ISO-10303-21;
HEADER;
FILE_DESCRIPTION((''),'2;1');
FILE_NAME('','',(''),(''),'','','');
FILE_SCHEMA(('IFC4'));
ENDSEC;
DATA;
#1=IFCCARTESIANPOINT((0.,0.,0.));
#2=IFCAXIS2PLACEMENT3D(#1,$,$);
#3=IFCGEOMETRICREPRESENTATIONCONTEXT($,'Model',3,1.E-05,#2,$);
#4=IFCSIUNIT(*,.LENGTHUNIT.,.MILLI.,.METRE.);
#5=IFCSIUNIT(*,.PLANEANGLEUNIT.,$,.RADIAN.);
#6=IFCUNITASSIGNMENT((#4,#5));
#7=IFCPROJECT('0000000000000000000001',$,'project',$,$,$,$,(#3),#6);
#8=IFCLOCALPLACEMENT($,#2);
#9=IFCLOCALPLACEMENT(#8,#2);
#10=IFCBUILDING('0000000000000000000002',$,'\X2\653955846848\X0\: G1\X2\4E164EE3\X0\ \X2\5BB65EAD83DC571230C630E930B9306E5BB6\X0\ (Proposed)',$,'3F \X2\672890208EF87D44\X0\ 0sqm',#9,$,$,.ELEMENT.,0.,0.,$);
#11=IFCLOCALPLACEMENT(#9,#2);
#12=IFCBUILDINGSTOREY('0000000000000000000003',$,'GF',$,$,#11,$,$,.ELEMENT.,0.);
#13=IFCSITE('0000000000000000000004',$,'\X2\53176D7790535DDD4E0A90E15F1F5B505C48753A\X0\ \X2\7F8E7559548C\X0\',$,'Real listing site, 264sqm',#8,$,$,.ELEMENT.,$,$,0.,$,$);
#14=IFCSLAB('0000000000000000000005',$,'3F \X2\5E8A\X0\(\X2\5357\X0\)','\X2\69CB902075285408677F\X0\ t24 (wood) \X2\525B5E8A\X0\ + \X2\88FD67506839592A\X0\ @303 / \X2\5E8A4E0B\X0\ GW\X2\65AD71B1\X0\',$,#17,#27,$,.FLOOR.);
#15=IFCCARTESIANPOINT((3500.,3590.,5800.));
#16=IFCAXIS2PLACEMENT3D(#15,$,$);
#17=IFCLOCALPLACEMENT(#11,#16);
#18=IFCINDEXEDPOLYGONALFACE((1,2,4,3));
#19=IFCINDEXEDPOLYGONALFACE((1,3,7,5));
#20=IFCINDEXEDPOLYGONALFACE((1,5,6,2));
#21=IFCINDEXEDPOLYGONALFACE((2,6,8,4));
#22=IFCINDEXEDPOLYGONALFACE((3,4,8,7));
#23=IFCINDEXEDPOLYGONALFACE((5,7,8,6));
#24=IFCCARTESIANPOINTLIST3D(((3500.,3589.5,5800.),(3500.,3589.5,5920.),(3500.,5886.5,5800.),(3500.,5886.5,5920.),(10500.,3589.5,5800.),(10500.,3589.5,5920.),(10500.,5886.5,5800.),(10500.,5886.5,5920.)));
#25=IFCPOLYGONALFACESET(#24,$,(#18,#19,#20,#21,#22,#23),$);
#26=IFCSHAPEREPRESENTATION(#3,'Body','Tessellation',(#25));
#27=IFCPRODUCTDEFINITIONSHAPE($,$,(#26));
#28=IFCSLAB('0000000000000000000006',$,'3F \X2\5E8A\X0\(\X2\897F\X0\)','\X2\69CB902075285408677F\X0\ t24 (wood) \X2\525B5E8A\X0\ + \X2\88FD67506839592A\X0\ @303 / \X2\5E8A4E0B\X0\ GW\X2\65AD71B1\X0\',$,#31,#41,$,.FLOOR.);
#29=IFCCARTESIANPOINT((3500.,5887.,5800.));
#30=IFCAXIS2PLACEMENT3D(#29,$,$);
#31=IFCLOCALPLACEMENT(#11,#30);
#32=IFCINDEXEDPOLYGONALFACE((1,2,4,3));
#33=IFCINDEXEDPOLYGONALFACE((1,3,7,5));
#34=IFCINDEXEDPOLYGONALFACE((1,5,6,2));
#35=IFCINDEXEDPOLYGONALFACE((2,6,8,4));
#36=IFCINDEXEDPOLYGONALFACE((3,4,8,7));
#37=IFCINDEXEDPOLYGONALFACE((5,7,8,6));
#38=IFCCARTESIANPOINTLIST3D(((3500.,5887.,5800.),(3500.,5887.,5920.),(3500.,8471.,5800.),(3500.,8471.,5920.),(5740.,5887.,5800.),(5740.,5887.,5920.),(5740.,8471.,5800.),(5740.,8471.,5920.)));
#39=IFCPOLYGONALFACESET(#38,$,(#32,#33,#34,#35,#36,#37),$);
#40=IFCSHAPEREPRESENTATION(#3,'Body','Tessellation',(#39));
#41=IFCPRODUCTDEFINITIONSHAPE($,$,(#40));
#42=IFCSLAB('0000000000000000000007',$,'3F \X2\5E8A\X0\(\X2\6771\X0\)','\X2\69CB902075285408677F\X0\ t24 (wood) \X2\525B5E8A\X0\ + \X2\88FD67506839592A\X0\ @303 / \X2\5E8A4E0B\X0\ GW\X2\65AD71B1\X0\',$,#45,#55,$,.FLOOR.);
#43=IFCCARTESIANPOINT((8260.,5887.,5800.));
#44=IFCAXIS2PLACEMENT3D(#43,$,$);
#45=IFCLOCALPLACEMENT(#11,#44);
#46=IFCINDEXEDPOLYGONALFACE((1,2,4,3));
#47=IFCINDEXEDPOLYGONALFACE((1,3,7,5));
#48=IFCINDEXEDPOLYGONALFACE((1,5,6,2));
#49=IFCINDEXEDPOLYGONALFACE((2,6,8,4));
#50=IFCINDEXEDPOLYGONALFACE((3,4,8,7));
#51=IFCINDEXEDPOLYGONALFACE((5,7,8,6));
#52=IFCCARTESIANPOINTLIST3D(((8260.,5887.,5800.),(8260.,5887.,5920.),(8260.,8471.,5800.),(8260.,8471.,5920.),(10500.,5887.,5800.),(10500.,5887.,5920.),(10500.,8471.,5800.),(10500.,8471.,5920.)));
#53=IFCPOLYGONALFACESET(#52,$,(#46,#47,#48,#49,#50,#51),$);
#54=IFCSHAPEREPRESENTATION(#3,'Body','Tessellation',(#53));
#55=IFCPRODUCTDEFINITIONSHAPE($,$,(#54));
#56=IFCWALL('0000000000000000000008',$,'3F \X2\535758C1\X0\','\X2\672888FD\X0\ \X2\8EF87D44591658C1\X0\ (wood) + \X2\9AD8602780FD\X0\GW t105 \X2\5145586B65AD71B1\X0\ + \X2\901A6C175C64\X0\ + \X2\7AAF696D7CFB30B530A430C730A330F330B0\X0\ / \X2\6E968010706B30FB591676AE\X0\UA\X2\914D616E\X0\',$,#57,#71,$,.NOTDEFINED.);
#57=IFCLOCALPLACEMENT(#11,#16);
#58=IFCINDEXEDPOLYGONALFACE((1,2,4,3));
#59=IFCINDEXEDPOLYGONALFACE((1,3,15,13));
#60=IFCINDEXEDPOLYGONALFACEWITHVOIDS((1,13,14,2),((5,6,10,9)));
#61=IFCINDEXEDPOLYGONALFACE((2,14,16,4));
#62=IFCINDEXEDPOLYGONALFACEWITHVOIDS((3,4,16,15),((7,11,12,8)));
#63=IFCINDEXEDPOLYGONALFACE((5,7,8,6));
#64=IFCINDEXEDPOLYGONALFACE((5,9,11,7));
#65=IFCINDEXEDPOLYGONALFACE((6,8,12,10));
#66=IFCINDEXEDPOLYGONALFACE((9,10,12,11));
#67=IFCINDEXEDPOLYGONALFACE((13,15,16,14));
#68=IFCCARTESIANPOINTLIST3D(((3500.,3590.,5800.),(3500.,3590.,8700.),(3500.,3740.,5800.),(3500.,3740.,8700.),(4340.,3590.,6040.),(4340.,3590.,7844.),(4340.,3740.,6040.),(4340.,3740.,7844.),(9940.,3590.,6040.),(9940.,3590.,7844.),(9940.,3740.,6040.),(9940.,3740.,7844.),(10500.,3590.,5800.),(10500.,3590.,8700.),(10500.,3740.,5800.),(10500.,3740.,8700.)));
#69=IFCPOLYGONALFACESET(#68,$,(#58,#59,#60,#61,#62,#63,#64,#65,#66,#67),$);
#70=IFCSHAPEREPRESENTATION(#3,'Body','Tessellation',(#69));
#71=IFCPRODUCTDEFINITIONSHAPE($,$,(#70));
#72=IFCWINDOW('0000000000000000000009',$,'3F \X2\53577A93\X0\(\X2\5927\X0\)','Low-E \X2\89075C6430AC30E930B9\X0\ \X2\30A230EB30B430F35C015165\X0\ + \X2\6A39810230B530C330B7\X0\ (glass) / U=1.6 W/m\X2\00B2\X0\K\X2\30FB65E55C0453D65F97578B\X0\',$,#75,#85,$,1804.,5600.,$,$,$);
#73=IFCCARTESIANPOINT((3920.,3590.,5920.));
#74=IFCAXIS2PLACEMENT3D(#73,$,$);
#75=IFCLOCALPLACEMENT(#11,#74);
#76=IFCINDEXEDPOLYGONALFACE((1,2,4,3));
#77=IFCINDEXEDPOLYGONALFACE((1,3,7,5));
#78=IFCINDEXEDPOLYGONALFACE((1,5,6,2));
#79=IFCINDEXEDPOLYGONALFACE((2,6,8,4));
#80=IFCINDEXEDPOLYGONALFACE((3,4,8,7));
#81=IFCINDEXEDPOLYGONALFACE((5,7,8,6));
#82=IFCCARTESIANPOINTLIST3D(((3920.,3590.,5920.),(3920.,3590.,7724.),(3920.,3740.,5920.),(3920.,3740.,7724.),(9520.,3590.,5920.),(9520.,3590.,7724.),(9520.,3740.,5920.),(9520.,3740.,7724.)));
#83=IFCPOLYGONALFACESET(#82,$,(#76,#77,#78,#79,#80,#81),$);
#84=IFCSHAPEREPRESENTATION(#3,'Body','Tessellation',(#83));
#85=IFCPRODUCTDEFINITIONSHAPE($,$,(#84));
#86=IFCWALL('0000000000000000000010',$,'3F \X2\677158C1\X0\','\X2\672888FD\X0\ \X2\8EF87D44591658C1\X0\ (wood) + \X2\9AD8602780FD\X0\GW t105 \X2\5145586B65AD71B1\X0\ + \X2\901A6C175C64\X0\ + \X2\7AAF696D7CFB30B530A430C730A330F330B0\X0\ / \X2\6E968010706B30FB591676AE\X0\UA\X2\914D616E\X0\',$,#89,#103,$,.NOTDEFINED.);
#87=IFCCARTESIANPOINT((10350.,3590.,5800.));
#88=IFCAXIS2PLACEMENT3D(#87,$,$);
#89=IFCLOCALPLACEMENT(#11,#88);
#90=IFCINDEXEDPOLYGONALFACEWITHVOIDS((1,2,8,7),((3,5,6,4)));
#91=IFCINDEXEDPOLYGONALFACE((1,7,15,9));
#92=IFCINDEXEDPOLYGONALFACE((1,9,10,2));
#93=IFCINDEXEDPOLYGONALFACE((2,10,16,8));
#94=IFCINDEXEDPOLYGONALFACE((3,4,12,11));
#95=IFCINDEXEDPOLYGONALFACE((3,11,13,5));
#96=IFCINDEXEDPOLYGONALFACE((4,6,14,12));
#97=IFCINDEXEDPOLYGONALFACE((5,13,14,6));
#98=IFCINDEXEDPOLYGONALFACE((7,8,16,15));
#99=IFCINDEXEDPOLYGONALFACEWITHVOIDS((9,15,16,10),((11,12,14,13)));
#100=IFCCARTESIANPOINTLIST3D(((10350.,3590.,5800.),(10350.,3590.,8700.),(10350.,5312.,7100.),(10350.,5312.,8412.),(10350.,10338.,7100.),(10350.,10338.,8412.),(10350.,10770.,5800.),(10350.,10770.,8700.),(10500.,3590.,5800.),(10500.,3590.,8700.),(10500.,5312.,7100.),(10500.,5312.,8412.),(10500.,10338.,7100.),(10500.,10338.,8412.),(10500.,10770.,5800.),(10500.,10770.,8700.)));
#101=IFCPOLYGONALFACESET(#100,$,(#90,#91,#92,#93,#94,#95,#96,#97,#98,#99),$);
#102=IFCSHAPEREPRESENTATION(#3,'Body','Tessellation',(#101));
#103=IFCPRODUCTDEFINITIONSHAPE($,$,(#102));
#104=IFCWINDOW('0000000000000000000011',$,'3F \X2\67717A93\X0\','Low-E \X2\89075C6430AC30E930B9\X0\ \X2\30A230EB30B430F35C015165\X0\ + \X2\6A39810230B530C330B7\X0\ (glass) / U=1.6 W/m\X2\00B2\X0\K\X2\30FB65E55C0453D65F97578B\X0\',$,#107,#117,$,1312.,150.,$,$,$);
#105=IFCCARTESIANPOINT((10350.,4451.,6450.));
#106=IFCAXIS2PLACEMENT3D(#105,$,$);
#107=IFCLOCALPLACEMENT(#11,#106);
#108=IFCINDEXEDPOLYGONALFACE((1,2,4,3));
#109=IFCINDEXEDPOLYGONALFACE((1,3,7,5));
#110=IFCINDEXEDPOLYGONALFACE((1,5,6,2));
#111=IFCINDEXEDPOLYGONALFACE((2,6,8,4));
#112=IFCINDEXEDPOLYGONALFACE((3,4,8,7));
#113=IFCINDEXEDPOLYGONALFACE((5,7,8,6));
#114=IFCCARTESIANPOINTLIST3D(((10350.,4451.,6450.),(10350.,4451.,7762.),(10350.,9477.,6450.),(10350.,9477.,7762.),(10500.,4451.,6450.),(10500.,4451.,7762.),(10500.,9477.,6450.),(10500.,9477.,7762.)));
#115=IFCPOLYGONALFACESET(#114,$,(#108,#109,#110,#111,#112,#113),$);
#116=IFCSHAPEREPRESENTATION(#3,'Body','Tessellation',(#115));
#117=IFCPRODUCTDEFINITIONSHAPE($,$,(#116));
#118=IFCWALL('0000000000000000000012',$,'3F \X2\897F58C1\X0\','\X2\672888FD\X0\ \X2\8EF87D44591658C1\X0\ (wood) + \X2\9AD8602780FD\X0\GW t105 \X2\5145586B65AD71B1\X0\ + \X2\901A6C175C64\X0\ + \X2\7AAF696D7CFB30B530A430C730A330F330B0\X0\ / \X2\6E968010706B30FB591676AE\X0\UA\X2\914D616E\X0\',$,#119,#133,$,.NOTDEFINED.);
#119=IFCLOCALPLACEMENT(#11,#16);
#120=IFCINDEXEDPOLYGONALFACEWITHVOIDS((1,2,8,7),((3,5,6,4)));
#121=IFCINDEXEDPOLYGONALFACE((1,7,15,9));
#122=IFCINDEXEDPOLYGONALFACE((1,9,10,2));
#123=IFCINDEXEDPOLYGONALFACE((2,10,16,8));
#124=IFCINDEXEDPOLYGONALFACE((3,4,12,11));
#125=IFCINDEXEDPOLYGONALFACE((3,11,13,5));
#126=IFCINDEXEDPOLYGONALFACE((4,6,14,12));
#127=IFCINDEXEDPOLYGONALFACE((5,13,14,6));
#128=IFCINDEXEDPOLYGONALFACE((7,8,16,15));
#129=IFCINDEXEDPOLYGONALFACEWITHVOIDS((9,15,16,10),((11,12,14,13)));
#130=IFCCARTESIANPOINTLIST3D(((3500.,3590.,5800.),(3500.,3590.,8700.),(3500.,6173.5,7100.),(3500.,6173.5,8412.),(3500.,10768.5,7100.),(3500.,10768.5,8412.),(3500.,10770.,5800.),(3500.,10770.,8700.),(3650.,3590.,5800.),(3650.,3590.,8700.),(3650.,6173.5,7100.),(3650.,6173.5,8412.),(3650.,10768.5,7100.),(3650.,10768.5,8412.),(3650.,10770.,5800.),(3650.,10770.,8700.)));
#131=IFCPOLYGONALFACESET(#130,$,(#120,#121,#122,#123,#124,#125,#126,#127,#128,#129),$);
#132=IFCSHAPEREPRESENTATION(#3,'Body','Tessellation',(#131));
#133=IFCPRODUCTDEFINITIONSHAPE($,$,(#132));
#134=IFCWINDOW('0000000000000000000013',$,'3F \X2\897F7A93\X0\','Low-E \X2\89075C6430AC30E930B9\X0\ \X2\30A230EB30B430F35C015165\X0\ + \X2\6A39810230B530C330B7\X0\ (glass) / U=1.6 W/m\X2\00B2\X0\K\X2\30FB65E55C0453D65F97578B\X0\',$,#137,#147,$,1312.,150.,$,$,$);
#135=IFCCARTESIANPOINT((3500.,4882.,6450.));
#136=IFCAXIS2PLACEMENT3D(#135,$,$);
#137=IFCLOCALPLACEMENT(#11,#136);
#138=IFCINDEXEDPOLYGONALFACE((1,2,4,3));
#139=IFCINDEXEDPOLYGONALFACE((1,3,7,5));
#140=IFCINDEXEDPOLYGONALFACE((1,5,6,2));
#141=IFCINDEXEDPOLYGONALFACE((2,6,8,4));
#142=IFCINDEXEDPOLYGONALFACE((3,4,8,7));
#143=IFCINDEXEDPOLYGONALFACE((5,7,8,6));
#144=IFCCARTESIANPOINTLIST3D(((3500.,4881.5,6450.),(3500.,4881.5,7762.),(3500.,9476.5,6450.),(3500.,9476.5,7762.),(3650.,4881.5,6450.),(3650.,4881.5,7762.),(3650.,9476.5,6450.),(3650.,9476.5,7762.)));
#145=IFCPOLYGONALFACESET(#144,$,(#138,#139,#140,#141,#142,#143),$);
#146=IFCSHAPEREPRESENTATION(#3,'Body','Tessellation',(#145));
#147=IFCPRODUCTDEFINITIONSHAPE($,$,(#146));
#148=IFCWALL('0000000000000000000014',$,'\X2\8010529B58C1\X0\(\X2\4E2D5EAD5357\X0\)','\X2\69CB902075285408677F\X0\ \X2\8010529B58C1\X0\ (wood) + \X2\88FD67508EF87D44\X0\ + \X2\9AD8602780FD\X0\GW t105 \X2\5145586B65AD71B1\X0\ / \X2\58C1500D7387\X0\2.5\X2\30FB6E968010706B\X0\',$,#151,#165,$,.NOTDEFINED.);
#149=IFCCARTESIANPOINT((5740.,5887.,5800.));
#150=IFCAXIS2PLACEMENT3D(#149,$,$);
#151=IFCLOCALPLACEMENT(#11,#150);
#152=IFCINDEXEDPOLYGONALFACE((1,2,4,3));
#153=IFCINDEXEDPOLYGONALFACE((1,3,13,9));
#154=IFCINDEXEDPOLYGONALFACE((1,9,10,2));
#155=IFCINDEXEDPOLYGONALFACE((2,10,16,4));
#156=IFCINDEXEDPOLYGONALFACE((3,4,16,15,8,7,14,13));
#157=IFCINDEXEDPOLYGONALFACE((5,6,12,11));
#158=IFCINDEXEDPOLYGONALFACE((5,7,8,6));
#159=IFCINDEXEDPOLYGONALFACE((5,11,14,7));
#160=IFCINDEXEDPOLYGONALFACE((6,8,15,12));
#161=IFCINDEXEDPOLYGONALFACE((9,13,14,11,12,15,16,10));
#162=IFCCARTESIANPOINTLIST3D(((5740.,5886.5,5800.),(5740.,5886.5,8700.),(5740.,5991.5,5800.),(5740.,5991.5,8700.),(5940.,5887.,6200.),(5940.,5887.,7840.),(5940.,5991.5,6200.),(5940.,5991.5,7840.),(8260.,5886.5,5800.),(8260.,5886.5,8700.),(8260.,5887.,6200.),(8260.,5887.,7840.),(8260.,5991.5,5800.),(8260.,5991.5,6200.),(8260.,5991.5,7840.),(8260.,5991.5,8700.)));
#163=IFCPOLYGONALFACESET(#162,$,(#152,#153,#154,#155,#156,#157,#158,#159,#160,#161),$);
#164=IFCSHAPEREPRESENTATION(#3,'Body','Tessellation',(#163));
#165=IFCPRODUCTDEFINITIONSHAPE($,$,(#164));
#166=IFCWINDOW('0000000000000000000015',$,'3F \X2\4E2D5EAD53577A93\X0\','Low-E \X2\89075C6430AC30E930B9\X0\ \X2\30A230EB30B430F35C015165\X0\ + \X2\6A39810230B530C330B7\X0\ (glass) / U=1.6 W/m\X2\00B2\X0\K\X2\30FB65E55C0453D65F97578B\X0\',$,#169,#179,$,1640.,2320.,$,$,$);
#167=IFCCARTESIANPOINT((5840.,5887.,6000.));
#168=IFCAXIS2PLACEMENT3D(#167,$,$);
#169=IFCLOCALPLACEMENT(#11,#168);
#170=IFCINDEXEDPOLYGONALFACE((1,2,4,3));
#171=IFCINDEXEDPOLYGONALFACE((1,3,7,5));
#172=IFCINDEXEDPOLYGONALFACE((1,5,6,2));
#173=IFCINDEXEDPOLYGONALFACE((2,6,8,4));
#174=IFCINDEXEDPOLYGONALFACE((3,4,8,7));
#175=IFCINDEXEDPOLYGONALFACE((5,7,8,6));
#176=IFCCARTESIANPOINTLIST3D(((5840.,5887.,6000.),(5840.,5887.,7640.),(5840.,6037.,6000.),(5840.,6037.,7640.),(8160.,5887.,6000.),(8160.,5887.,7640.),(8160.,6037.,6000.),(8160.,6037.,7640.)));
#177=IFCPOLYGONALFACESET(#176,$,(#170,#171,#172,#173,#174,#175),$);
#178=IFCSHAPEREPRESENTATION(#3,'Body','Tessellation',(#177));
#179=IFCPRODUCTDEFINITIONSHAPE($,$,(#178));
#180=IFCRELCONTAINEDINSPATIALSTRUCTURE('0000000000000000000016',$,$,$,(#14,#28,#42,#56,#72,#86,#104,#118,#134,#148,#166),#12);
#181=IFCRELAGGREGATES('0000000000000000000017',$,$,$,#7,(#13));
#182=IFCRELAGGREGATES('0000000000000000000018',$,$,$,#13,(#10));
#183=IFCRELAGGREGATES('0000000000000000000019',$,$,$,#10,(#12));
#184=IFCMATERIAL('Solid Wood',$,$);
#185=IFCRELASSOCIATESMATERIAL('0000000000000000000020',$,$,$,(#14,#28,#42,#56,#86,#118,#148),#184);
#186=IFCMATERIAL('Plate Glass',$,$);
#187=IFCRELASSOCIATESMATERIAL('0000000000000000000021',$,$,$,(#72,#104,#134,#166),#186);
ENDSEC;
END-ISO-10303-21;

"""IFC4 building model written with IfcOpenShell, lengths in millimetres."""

from ifc_helpers import new_model, si_unit, frame, frame_2d, origin, place, context, project, spatial, rectangle, extrude, material, element, fill, save


model = new_model("IFC4")

# Units and contexts
model_context = context("Model", 3, precision=1e-05, world=origin())
ifc_project = project(units=[si_unit("LENGTHUNIT", "METRE", prefix="MILLI"), si_unit("PLANEANGLEUNIT", "RADIAN")], contexts=[model_context])

# Site, building, storey
site_placement = place(None, origin())
site = spatial("IfcSite", under=ifc_project, at=site_placement, Name="北海道川上郡弟子屈町 美留和", ObjectType="Real listing site, 264sqm", CompositionType="ELEMENT", RefElevation=0.0)
building_placement = place(site_placement, origin())
building = spatial("IfcBuilding", under=site, at=building_placement, Name="改善案: G1世代 家庭菜園テラスの家 (Proposed)", ObjectType="3F 木造軸組 0sqm", CompositionType="ELEMENT", ElevationOfRefHeight=0.0, ElevationOfTerrain=0.0)
storey_placement = place(building_placement, origin())
storey = spatial("IfcBuildingStorey", under=building, at=storey_placement, Name="GF", CompositionType="ELEMENT", Elevation=0.0)

# Slabs
ifc_material_1 = material(Name="Solid Wood")
slab_1_placement = place(storey_placement, frame((3500.0, 3590.0, 5800.0)))
element("IfcSlab", 1, at=slab_1_placement, inside=storey, material=ifc_material_1, Name="3F 床(南)", Description="構造用合板 t24 (wood) 剛床 + 製材根太 @303 / 床下 GW断熱", PredefinedType="FLOOR", context=model_context, shape_type="SweptSolid", body=[
    extrude(rectangle(XDim=7000.0, YDim=2297.0, at=frame_2d((3500.0, 1148.0))), frame((3500.0, 3590.0, 5800.0)), (0.0, 0.0, 1.0), 120.0),
])
slab_2_placement = place(storey_placement, frame((3500.0, 5887.0, 5800.0)))
element("IfcSlab", 2, at=slab_2_placement, inside=storey, material=ifc_material_1, Name="3F 床(西)", Description="構造用合板 t24 (wood) 剛床 + 製材根太 @303 / 床下 GW断熱", PredefinedType="FLOOR", context=model_context, shape_type="SweptSolid", body=[
    extrude(rectangle(XDim=2240.0, YDim=2584.0, at=frame_2d((1120.0, 1292.0))), frame((3500.0, 5887.0, 5800.0)), (0.0, 0.0, 1.0), 120.0),
])
slab_3_placement = place(storey_placement, frame((8260.0, 5887.0, 5800.0)))
element("IfcSlab", 3, at=slab_3_placement, inside=storey, material=ifc_material_1, Name="3F 床(東)", Description="構造用合板 t24 (wood) 剛床 + 製材根太 @303 / 床下 GW断熱", PredefinedType="FLOOR", context=model_context, shape_type="SweptSolid", body=[
    extrude(rectangle(XDim=2240.0, YDim=2584.0, at=frame_2d((1120.0, 1292.0))), frame((8260.0, 5887.0, 5800.0)), (0.0, 0.0, 1.0), 120.0),
])

# Walls, openings, windows
wall_1_placement = place(storey_placement, frame((3500.0, 3590.0, 5800.0)))
wall_1 = element("IfcWall", 4, at=wall_1_placement, inside=storey, material=ifc_material_1, Name="3F 南壁", Description="木製 軸組外壁 (wood) + 高性能GW t105 充填断熱 + 通気層 + 窯業系サイディング / 準耐火・外皮UA配慮", PredefinedType="NOTDEFINED", context=model_context, shape_type="SweptSolid", body=[
    extrude(rectangle(XDim=7000.0, YDim=150.0, at=frame_2d((3500.0, 75.0))), frame((3500.0, 3590.0, 5800.0)), (0.0, 0.0, 1.0), 2900.0),
])
opening_1_placement = place(storey_placement, frame((3920.0, 3590.0, 5920.0)))
opening_1 = element("IfcOpeningElement", 5, at=opening_1_placement, cuts=wall_1, PredefinedType="NOTDEFINED", context=model_context, shape_type="SweptSolid", body=[
    extrude(rectangle(XDim=5600.0, YDim=150.0, at=frame_2d((2800.0, 75.0))), frame((3920.0, 3590.0, 5920.0)), (0.0, 0.0, 1.0), 1804.0),
])
ifc_material_2 = material(Name="Plate Glass")
window_1_placement = place(storey_placement, frame((3920.0, 3590.0, 5920.0)))
window_1 = element("IfcWindow", 6, at=window_1_placement, inside=storey, material=ifc_material_2, Name="3F 南窓(大)", Description="Low-E 複層ガラス アルゴン封入 + 樹脂サッシ (glass) / U=1.6 W/m²K・日射取得型", OverallHeight=1804.0, OverallWidth=5600.0, context=model_context, shape_type="SweptSolid", body=[
    extrude(rectangle(XDim=5600.0, YDim=150.0, at=frame_2d((2800.0, 75.0))), frame((3920.0, 3590.0, 5920.0)), (0.0, 0.0, 1.0), 1804.0),
])
fill(opening_1, window_1)
wall_2_placement = place(storey_placement, frame((10350.0, 3590.0, 5800.0)))
wall_2 = element("IfcWall", 7, at=wall_2_placement, inside=storey, material=ifc_material_1, Name="3F 東壁", Description="木製 軸組外壁 (wood) + 高性能GW t105 充填断熱 + 通気層 + 窯業系サイディング / 準耐火・外皮UA配慮", PredefinedType="NOTDEFINED", context=model_context, shape_type="SweptSolid", body=[
    extrude(rectangle(XDim=150.0, YDim=7180.0, at=frame_2d((75.0, 3590.0))), frame((10350.0, 3590.0, 5800.0)), (0.0, 0.0, 1.0), 2900.0),
])
opening_2_placement = place(storey_placement, frame((10350.0, 4451.0, 6450.0)))
opening_2 = element("IfcOpeningElement", 8, at=opening_2_placement, cuts=wall_2, PredefinedType="NOTDEFINED", context=model_context, shape_type="SweptSolid", body=[
    extrude(rectangle(XDim=150.0, YDim=5026.0, at=frame_2d((75.0, 2513.0))), frame((10350.0, 4451.0, 6450.0)), (0.0, 0.0, 1.0), 1312.0),
])
window_2_placement = place(storey_placement, frame((10350.0, 4451.0, 6450.0)))
window_2 = element("IfcWindow", 9, at=window_2_placement, inside=storey, material=ifc_material_2, Name="3F 東窓", Description="Low-E 複層ガラス アルゴン封入 + 樹脂サッシ (glass) / U=1.6 W/m²K・日射取得型", OverallHeight=1312.0, OverallWidth=150.0, context=model_context, shape_type="SweptSolid", body=[
    extrude(rectangle(XDim=150.0, YDim=5026.0, at=frame_2d((75.0, 2513.0))), frame((10350.0, 4451.0, 6450.0)), (0.0, 0.0, 1.0), 1312.0),
])
fill(opening_2, window_2)
wall_3_placement = place(storey_placement, frame((3500.0, 3590.0, 5800.0)))
wall_3 = element("IfcWall", 10, at=wall_3_placement, inside=storey, material=ifc_material_1, Name="3F 西壁", Description="木製 軸組外壁 (wood) + 高性能GW t105 充填断熱 + 通気層 + 窯業系サイディング / 準耐火・外皮UA配慮", PredefinedType="NOTDEFINED", context=model_context, shape_type="SweptSolid", body=[
    extrude(rectangle(XDim=150.0, YDim=7180.0, at=frame_2d((75.0, 3590.0))), frame((3500.0, 3590.0, 5800.0)), (0.0, 0.0, 1.0), 2900.0),
])
opening_3_placement = place(storey_placement, frame((3500.0, 4882.0, 6450.0)))
opening_3 = element("IfcOpeningElement", 11, at=opening_3_placement, cuts=wall_3, PredefinedType="NOTDEFINED", context=model_context, shape_type="SweptSolid", body=[
    extrude(rectangle(XDim=150.0, YDim=4595.0, at=frame_2d((75.0, 2297.0))), frame((3500.0, 4882.0, 6450.0)), (0.0, 0.0, 1.0), 1312.0),
])
window_3_placement = place(storey_placement, frame((3500.0, 4882.0, 6450.0)))
window_3 = element("IfcWindow", 12, at=window_3_placement, inside=storey, material=ifc_material_2, Name="3F 西窓", Description="Low-E 複層ガラス アルゴン封入 + 樹脂サッシ (glass) / U=1.6 W/m²K・日射取得型", OverallHeight=1312.0, OverallWidth=150.0, context=model_context, shape_type="SweptSolid", body=[
    extrude(rectangle(XDim=150.0, YDim=4595.0, at=frame_2d((75.0, 2297.0))), frame((3500.0, 4882.0, 6450.0)), (0.0, 0.0, 1.0), 1312.0),
])
fill(opening_3, window_3)
wall_4_placement = place(storey_placement, frame((5740.0, 5887.0, 5800.0)))
wall_4 = element("IfcWall", 13, at=wall_4_placement, inside=storey, material=ifc_material_1, Name="耐力壁(中庭南)", Description="構造用合板 耐力壁 (wood) + 製材軸組 + 高性能GW t105 充填断熱 / 壁倍率2.5・準耐火", PredefinedType="NOTDEFINED", context=model_context, shape_type="SweptSolid", body=[
    extrude(rectangle(XDim=2520.0, YDim=105.0, at=frame_2d((1260.0, 52.0))), frame((5740.0, 5887.0, 5800.0)), (0.0, 0.0, 1.0), 2900.0),
])
opening_4_placement = place(storey_placement, frame((5840.0, 5887.0, 6000.0)))
opening_4 = element("IfcOpeningElement", 14, at=opening_4_placement, cuts=wall_4, PredefinedType="NOTDEFINED", context=model_context, shape_type="SweptSolid", body=[
    extrude(rectangle(XDim=2320.0, YDim=150.0, at=frame_2d((1160.0, 75.0))), frame((5840.0, 5887.0, 6000.0)), (0.0, 0.0, 1.0), 1640.0),
])
window_4_placement = place(storey_placement, frame((5840.0, 5887.0, 6000.0)))
window_4 = element("IfcWindow", 15, at=window_4_placement, inside=storey, material=ifc_material_2, Name="3F 中庭南窓", Description="Low-E 複層ガラス アルゴン封入 + 樹脂サッシ (glass) / U=1.6 W/m²K・日射取得型", OverallHeight=1640.0, OverallWidth=2320.0, context=model_context, shape_type="SweptSolid", body=[
    extrude(rectangle(XDim=2320.0, YDim=150.0, at=frame_2d((1160.0, 75.0))), frame((5840.0, 5887.0, 6000.0)), (0.0, 0.0, 1.0), 1640.0),
])
fill(opening_4, window_4)

save(model, "model.ifc")
